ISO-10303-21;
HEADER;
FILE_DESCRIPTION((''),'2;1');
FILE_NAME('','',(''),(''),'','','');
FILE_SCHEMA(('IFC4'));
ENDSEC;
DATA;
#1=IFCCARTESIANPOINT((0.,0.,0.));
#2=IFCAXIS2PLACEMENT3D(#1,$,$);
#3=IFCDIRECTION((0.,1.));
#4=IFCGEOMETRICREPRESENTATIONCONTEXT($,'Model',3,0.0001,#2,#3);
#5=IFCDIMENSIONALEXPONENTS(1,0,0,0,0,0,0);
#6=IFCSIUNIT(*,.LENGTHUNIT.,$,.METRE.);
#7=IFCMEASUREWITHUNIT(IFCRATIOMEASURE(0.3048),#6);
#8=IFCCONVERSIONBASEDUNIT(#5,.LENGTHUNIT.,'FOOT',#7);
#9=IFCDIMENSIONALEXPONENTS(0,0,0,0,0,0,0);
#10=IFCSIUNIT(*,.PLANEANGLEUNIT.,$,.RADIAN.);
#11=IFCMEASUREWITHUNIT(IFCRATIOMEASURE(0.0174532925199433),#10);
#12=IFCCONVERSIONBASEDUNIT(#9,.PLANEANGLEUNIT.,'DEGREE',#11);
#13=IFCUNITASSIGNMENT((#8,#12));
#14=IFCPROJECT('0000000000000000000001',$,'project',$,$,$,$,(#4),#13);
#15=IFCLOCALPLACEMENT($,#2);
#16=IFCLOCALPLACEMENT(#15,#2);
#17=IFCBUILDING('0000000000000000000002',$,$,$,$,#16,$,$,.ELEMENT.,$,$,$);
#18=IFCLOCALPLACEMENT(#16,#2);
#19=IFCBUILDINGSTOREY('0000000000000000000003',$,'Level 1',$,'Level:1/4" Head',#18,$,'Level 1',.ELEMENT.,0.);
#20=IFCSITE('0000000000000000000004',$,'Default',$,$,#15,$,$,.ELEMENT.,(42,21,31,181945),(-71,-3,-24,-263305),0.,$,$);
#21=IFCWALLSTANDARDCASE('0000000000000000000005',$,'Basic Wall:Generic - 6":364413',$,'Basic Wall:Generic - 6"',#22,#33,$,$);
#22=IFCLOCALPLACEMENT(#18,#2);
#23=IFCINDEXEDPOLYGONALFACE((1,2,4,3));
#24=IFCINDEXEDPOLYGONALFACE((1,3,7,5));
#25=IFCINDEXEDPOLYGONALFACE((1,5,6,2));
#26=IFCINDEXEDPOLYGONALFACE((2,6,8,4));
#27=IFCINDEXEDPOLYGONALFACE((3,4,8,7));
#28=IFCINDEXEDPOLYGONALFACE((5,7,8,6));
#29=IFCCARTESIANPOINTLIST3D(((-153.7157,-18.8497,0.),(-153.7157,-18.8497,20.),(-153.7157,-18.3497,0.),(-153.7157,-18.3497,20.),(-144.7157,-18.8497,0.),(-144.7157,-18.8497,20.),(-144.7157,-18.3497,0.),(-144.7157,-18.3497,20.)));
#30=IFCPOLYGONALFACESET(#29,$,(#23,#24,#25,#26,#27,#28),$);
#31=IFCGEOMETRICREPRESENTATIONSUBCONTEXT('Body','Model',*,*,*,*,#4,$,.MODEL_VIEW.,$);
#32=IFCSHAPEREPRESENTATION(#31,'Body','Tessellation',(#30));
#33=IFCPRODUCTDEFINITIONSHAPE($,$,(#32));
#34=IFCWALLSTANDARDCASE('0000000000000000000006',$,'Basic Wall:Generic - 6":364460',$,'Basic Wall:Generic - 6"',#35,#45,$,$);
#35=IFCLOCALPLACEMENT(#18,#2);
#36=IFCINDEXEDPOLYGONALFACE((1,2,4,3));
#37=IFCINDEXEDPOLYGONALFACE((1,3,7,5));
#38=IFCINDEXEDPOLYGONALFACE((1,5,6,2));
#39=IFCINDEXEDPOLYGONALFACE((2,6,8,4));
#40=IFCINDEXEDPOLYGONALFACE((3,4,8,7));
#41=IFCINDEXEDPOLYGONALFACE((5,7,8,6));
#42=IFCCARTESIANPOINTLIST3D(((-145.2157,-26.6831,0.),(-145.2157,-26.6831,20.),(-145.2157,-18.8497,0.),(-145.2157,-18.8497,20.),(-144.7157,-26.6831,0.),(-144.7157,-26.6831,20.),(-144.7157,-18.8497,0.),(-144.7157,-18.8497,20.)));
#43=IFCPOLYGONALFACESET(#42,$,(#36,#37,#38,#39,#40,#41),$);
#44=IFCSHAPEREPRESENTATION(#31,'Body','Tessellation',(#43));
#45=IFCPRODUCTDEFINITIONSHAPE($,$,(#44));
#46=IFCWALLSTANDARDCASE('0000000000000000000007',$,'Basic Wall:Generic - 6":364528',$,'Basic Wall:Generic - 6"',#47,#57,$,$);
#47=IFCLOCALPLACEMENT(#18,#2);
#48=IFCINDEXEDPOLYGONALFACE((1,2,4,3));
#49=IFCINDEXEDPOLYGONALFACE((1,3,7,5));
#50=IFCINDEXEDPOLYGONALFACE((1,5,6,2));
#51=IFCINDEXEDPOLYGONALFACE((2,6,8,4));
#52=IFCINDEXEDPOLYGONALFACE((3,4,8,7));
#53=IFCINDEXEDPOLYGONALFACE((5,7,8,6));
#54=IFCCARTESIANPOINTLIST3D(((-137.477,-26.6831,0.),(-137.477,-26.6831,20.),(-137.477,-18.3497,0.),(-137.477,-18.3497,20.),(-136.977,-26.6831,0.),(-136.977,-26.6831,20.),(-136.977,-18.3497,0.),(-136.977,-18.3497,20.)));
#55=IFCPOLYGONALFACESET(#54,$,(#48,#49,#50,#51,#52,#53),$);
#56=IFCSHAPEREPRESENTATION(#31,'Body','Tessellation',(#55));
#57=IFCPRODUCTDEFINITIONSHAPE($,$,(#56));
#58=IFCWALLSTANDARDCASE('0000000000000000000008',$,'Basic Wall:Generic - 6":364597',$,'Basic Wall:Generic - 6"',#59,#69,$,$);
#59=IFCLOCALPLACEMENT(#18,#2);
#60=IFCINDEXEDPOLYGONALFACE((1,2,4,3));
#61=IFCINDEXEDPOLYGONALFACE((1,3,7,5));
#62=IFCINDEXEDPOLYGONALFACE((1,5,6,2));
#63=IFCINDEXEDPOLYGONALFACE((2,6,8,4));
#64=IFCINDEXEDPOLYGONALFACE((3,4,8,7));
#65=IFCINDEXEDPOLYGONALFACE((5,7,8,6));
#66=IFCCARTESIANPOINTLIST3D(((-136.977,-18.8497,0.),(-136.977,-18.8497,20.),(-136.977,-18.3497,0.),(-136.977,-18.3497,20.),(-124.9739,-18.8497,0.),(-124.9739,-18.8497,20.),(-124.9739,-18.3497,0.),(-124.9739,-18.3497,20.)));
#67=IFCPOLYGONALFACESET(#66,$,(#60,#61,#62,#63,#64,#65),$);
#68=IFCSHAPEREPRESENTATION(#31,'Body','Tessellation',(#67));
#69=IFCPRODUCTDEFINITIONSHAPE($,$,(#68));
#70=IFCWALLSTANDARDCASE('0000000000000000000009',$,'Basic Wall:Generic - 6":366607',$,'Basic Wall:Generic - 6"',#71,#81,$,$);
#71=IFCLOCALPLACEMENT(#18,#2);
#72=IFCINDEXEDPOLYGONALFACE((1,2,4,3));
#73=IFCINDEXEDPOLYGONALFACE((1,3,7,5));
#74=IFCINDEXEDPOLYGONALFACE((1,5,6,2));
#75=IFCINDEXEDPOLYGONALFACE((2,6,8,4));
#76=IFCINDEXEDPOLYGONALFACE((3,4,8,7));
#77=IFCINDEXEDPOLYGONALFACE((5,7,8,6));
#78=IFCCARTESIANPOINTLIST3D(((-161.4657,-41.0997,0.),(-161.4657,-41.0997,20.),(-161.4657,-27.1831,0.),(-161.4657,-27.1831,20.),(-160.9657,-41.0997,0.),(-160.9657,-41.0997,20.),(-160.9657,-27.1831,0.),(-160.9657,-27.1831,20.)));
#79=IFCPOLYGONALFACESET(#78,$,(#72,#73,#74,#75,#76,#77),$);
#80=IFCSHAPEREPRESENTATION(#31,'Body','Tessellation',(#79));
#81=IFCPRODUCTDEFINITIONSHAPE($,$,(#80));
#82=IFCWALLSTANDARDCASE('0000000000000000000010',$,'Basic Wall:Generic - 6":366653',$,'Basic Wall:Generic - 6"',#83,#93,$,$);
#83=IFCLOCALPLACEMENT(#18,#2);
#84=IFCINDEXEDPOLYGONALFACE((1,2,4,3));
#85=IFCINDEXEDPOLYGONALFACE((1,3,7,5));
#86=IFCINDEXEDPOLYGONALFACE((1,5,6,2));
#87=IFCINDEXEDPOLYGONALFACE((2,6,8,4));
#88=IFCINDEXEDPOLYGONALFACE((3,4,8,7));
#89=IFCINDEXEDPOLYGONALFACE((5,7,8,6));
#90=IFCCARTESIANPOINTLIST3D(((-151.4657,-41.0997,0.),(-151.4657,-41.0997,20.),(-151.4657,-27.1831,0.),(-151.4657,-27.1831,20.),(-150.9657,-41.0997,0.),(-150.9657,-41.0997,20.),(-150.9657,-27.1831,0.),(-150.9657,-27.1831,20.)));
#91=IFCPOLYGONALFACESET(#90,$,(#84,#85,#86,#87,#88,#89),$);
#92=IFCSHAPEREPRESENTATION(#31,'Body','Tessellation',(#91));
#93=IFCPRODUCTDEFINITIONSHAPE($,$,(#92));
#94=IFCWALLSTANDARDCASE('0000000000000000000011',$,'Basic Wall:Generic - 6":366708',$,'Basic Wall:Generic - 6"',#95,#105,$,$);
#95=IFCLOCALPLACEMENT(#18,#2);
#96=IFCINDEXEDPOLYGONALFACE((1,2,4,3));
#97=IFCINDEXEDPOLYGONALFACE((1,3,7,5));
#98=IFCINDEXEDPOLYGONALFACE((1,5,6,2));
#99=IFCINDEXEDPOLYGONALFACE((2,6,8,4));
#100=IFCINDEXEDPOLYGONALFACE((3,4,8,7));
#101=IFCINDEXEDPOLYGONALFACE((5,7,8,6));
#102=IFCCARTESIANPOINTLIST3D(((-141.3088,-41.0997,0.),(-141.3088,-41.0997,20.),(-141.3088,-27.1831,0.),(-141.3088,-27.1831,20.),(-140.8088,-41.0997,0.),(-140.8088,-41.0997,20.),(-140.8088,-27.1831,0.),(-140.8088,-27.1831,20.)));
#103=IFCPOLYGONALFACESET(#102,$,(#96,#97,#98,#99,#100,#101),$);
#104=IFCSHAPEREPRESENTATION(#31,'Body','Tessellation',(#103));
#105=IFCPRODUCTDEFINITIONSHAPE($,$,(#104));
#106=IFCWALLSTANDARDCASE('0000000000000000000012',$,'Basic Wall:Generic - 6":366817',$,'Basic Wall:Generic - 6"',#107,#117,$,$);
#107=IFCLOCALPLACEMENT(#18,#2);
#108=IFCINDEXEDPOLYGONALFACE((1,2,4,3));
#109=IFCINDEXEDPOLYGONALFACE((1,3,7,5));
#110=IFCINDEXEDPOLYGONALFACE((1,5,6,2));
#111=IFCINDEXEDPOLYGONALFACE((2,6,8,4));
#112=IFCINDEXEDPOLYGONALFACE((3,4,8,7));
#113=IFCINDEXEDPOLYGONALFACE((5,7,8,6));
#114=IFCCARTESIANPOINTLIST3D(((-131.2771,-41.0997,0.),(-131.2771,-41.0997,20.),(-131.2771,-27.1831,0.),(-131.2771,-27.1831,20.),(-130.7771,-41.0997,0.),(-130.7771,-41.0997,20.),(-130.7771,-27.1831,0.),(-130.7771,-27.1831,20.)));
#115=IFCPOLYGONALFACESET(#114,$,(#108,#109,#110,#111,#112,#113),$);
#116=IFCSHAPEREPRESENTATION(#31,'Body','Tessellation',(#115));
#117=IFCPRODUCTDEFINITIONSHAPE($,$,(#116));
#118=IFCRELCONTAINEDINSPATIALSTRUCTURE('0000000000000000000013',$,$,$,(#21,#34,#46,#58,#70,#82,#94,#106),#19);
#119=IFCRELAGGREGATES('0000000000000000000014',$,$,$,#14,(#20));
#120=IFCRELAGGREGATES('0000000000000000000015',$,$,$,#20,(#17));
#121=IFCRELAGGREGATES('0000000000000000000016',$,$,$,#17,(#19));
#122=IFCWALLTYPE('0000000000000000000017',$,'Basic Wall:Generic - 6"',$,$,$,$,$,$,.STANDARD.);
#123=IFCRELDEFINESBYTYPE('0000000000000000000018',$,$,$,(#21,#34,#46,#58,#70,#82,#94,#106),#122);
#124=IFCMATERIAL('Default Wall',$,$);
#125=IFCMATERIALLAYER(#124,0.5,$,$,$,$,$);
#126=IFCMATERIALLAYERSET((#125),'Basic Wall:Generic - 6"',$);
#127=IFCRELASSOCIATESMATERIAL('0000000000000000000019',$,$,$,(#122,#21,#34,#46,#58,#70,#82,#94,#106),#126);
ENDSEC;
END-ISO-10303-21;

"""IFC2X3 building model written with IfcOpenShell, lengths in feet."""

from ifc_helpers import new_model, entity, si_unit, converted_unit, direction, frame, frame_2d, origin, place, context, subcontext, project, spatial, rectangle, extrude, material, layer, layer_set, layer_usage, type_object, element, save


model = new_model("IFC2X3")

# Units and contexts
model_context = context("Model", 3, precision=0.0001, world=origin(), true_north=direction((0.0, 1.0)))
body_context = subcontext(model_context, "Body", "Model", "MODEL_VIEW")
ifc_project = project(units=[converted_unit("LENGTHUNIT", "FOOT", entity("IfcRatioMeasure", 0.3048), si_unit("LENGTHUNIT", "METRE"), dimensions=[1, 0, 0, 0, 0, 0, 0]), converted_unit("PLANEANGLEUNIT", "DEGREE", entity("IfcRatioMeasure", 0.0174532925199433), si_unit("PLANEANGLEUNIT", "RADIAN"), dimensions=[0, 0, 0, 0, 0, 0, 0])], contexts=[model_context])

# Site, building, storey
site_placement = place(None, origin())
site = spatial("IfcSite", under=ifc_project, at=site_placement, Name="Default", CompositionType="ELEMENT", RefLatitude=(42, 21, 31, 181945), RefLongitude=(-71, -3, -24, -263305), RefElevation=0.0)
building_placement = place(site_placement, origin())
building = spatial("IfcBuilding", under=site, at=building_placement, CompositionType="ELEMENT")
storey_placement = place(building_placement, origin())
storey = spatial("IfcBuildingStorey", under=building, at=storey_placement, Name="Level 1", ObjectType="Level:1/4\" Head", LongName="Level 1", CompositionType="ELEMENT", Elevation=0.0)

# Walls
ifc_material = material(Name="Default Wall")
ifc_layer_1 = layer(ifc_material, 0.5)
ifc_layer_set_1 = layer_set([ifc_layer_1], Name="Basic Wall:Generic - 6\"")
wall_type_1 = type_object("IfcWallType", Name="Basic Wall:Generic - 6\"", PredefinedType="STANDARD", material=ifc_layer_set_1)
ifc_layer_usage_1 = layer_usage(ifc_layer_set_1, "AXIS2", "NEGATIVE", 0.25)
wall_1_placement = place(storey_placement, frame((-153.7157, -18.5997, 0.0)))
element("IfcWallStandardCase", 1, at=wall_1_placement, inside=storey, type_object=wall_type_1, material=ifc_layer_usage_1, Name="Basic Wall:Generic - 6\":364413", ObjectType="Basic Wall:Generic - 6\"", context=body_context, shape_type="SweptSolid", body=[
    extrude(rectangle(XDim=9.0, YDim=0.5, at=frame_2d((4.5, 0.0), x_axis=(-1.0, 0.0))), origin(), (0.0, 0.0, 1.0), 20.0),
])
ifc_layer_usage_2 = layer_usage(ifc_layer_set_1, "AXIS2", "NEGATIVE", 0.25)
wall_2_placement = place(storey_placement, frame((-144.9657, -18.8497, 0.0), z_axis=(0.0, 0.0, 1.0), x_axis=(0.0, -1.0, 0.0)))
element("IfcWallStandardCase", 2, at=wall_2_placement, inside=storey, type_object=wall_type_1, material=ifc_layer_usage_2, Name="Basic Wall:Generic - 6\":364460", ObjectType="Basic Wall:Generic - 6\"", context=body_context, shape_type="SweptSolid", body=[
    extrude(rectangle(XDim=7.8333, YDim=0.5, at=frame_2d((3.9167, 0.0), x_axis=(-1.0, 0.0))), origin(), (0.0, 0.0, 1.0), 20.0),
])
ifc_layer_usage_3 = layer_usage(ifc_layer_set_1, "AXIS2", "NEGATIVE", 0.25)
wall_3_placement = place(storey_placement, frame((-137.227, -26.6831, 0.0), z_axis=(0.0, 0.0, 1.0), x_axis=(0.0, 1.0, 0.0)))
element("IfcWallStandardCase", 3, at=wall_3_placement, inside=storey, type_object=wall_type_1, material=ifc_layer_usage_3, Name="Basic Wall:Generic - 6\":364528", ObjectType="Basic Wall:Generic - 6\"", context=body_context, shape_type="SweptSolid", body=[
    extrude(rectangle(XDim=8.3333, YDim=0.5, at=frame_2d((4.1667, 0.0), x_axis=(-1.0, 0.0))), origin(), (0.0, 0.0, 1.0), 20.0),
])
ifc_layer_usage_4 = layer_usage(ifc_layer_set_1, "AXIS2", "NEGATIVE", 0.25)
wall_4_placement = place(storey_placement, frame((-136.977, -18.5997, 0.0)))
element("IfcWallStandardCase", 4, at=wall_4_placement, inside=storey, type_object=wall_type_1, material=ifc_layer_usage_4, Name="Basic Wall:Generic - 6\":364597", ObjectType="Basic Wall:Generic - 6\"", context=body_context, shape_type="SweptSolid", body=[
    extrude(rectangle(XDim=12.0031, YDim=0.5, at=frame_2d((6.0015, 0.0), x_axis=(-1.0, 0.0))), origin(), (0.0, 0.0, 1.0), 20.0),
])
ifc_layer_usage_5 = layer_usage(ifc_layer_set_1, "AXIS2", "NEGATIVE", 0.25)
wall_5_placement = place(storey_placement, frame((-161.2157, -27.1831, 0.0), z_axis=(0.0, 0.0, 1.0), x_axis=(0.0, -1.0, 0.0)))
element("IfcWallStandardCase", 5, at=wall_5_placement, inside=storey, type_object=wall_type_1, material=ifc_layer_usage_5, Name="Basic Wall:Generic - 6\":366607", ObjectType="Basic Wall:Generic - 6\"", context=body_context, shape_type="SweptSolid", body=[
    extrude(rectangle(XDim=13.9167, YDim=0.5, at=frame_2d((6.9583, 0.0), x_axis=(-1.0, 0.0))), origin(), (0.0, 0.0, 1.0), 20.0),
])
ifc_layer_usage_6 = layer_usage(ifc_layer_set_1, "AXIS2", "NEGATIVE", 0.25)
wall_6_placement = place(storey_placement, frame((-151.2157, -41.0997, 0.0), z_axis=(0.0, 0.0, 1.0), x_axis=(0.0, 1.0, 0.0)))
element("IfcWallStandardCase", 6, at=wall_6_placement, inside=storey, type_object=wall_type_1, material=ifc_layer_usage_6, Name="Basic Wall:Generic - 6\":366653", ObjectType="Basic Wall:Generic - 6\"", context=body_context, shape_type="SweptSolid", body=[
    extrude(rectangle(XDim=13.9167, YDim=0.5, at=frame_2d((6.9583, 0.0), x_axis=(-1.0, 0.0))), origin(), (0.0, 0.0, 1.0), 20.0),
])
ifc_layer_usage_7 = layer_usage(ifc_layer_set_1, "AXIS2", "NEGATIVE", 0.25)
wall_7_placement = place(storey_placement, frame((-141.0588, -27.1831, 0.0), z_axis=(0.0, 0.0, 1.0), x_axis=(0.0, -1.0, 0.0)))
element("IfcWallStandardCase", 7, at=wall_7_placement, inside=storey, type_object=wall_type_1, material=ifc_layer_usage_7, Name="Basic Wall:Generic - 6\":366708", ObjectType="Basic Wall:Generic - 6\"", context=body_context, shape_type="SweptSolid", body=[
    extrude(rectangle(XDim=13.9167, YDim=0.5, at=frame_2d((6.9583, 0.0), x_axis=(-1.0, 0.0))), origin(), (0.0, 0.0, 1.0), 20.0),
])
ifc_layer_usage_8 = layer_usage(ifc_layer_set_1, "AXIS2", "NEGATIVE", 0.25)
wall_8_placement = place(storey_placement, frame((-131.0271, -41.0997, 0.0), z_axis=(0.0, 0.0, 1.0), x_axis=(0.0, 1.0, 0.0)))
element("IfcWallStandardCase", 8, at=wall_8_placement, inside=storey, type_object=wall_type_1, material=ifc_layer_usage_8, Name="Basic Wall:Generic - 6\":366817", ObjectType="Basic Wall:Generic - 6\"", context=body_context, shape_type="SweptSolid", body=[
    extrude(rectangle(XDim=13.9167, YDim=0.5, at=frame_2d((6.9583, 0.0), x_axis=(-1.0, 0.0))), origin(), (0.0, 0.0, 1.0), 20.0),
])

save(model, "model.ifc")
